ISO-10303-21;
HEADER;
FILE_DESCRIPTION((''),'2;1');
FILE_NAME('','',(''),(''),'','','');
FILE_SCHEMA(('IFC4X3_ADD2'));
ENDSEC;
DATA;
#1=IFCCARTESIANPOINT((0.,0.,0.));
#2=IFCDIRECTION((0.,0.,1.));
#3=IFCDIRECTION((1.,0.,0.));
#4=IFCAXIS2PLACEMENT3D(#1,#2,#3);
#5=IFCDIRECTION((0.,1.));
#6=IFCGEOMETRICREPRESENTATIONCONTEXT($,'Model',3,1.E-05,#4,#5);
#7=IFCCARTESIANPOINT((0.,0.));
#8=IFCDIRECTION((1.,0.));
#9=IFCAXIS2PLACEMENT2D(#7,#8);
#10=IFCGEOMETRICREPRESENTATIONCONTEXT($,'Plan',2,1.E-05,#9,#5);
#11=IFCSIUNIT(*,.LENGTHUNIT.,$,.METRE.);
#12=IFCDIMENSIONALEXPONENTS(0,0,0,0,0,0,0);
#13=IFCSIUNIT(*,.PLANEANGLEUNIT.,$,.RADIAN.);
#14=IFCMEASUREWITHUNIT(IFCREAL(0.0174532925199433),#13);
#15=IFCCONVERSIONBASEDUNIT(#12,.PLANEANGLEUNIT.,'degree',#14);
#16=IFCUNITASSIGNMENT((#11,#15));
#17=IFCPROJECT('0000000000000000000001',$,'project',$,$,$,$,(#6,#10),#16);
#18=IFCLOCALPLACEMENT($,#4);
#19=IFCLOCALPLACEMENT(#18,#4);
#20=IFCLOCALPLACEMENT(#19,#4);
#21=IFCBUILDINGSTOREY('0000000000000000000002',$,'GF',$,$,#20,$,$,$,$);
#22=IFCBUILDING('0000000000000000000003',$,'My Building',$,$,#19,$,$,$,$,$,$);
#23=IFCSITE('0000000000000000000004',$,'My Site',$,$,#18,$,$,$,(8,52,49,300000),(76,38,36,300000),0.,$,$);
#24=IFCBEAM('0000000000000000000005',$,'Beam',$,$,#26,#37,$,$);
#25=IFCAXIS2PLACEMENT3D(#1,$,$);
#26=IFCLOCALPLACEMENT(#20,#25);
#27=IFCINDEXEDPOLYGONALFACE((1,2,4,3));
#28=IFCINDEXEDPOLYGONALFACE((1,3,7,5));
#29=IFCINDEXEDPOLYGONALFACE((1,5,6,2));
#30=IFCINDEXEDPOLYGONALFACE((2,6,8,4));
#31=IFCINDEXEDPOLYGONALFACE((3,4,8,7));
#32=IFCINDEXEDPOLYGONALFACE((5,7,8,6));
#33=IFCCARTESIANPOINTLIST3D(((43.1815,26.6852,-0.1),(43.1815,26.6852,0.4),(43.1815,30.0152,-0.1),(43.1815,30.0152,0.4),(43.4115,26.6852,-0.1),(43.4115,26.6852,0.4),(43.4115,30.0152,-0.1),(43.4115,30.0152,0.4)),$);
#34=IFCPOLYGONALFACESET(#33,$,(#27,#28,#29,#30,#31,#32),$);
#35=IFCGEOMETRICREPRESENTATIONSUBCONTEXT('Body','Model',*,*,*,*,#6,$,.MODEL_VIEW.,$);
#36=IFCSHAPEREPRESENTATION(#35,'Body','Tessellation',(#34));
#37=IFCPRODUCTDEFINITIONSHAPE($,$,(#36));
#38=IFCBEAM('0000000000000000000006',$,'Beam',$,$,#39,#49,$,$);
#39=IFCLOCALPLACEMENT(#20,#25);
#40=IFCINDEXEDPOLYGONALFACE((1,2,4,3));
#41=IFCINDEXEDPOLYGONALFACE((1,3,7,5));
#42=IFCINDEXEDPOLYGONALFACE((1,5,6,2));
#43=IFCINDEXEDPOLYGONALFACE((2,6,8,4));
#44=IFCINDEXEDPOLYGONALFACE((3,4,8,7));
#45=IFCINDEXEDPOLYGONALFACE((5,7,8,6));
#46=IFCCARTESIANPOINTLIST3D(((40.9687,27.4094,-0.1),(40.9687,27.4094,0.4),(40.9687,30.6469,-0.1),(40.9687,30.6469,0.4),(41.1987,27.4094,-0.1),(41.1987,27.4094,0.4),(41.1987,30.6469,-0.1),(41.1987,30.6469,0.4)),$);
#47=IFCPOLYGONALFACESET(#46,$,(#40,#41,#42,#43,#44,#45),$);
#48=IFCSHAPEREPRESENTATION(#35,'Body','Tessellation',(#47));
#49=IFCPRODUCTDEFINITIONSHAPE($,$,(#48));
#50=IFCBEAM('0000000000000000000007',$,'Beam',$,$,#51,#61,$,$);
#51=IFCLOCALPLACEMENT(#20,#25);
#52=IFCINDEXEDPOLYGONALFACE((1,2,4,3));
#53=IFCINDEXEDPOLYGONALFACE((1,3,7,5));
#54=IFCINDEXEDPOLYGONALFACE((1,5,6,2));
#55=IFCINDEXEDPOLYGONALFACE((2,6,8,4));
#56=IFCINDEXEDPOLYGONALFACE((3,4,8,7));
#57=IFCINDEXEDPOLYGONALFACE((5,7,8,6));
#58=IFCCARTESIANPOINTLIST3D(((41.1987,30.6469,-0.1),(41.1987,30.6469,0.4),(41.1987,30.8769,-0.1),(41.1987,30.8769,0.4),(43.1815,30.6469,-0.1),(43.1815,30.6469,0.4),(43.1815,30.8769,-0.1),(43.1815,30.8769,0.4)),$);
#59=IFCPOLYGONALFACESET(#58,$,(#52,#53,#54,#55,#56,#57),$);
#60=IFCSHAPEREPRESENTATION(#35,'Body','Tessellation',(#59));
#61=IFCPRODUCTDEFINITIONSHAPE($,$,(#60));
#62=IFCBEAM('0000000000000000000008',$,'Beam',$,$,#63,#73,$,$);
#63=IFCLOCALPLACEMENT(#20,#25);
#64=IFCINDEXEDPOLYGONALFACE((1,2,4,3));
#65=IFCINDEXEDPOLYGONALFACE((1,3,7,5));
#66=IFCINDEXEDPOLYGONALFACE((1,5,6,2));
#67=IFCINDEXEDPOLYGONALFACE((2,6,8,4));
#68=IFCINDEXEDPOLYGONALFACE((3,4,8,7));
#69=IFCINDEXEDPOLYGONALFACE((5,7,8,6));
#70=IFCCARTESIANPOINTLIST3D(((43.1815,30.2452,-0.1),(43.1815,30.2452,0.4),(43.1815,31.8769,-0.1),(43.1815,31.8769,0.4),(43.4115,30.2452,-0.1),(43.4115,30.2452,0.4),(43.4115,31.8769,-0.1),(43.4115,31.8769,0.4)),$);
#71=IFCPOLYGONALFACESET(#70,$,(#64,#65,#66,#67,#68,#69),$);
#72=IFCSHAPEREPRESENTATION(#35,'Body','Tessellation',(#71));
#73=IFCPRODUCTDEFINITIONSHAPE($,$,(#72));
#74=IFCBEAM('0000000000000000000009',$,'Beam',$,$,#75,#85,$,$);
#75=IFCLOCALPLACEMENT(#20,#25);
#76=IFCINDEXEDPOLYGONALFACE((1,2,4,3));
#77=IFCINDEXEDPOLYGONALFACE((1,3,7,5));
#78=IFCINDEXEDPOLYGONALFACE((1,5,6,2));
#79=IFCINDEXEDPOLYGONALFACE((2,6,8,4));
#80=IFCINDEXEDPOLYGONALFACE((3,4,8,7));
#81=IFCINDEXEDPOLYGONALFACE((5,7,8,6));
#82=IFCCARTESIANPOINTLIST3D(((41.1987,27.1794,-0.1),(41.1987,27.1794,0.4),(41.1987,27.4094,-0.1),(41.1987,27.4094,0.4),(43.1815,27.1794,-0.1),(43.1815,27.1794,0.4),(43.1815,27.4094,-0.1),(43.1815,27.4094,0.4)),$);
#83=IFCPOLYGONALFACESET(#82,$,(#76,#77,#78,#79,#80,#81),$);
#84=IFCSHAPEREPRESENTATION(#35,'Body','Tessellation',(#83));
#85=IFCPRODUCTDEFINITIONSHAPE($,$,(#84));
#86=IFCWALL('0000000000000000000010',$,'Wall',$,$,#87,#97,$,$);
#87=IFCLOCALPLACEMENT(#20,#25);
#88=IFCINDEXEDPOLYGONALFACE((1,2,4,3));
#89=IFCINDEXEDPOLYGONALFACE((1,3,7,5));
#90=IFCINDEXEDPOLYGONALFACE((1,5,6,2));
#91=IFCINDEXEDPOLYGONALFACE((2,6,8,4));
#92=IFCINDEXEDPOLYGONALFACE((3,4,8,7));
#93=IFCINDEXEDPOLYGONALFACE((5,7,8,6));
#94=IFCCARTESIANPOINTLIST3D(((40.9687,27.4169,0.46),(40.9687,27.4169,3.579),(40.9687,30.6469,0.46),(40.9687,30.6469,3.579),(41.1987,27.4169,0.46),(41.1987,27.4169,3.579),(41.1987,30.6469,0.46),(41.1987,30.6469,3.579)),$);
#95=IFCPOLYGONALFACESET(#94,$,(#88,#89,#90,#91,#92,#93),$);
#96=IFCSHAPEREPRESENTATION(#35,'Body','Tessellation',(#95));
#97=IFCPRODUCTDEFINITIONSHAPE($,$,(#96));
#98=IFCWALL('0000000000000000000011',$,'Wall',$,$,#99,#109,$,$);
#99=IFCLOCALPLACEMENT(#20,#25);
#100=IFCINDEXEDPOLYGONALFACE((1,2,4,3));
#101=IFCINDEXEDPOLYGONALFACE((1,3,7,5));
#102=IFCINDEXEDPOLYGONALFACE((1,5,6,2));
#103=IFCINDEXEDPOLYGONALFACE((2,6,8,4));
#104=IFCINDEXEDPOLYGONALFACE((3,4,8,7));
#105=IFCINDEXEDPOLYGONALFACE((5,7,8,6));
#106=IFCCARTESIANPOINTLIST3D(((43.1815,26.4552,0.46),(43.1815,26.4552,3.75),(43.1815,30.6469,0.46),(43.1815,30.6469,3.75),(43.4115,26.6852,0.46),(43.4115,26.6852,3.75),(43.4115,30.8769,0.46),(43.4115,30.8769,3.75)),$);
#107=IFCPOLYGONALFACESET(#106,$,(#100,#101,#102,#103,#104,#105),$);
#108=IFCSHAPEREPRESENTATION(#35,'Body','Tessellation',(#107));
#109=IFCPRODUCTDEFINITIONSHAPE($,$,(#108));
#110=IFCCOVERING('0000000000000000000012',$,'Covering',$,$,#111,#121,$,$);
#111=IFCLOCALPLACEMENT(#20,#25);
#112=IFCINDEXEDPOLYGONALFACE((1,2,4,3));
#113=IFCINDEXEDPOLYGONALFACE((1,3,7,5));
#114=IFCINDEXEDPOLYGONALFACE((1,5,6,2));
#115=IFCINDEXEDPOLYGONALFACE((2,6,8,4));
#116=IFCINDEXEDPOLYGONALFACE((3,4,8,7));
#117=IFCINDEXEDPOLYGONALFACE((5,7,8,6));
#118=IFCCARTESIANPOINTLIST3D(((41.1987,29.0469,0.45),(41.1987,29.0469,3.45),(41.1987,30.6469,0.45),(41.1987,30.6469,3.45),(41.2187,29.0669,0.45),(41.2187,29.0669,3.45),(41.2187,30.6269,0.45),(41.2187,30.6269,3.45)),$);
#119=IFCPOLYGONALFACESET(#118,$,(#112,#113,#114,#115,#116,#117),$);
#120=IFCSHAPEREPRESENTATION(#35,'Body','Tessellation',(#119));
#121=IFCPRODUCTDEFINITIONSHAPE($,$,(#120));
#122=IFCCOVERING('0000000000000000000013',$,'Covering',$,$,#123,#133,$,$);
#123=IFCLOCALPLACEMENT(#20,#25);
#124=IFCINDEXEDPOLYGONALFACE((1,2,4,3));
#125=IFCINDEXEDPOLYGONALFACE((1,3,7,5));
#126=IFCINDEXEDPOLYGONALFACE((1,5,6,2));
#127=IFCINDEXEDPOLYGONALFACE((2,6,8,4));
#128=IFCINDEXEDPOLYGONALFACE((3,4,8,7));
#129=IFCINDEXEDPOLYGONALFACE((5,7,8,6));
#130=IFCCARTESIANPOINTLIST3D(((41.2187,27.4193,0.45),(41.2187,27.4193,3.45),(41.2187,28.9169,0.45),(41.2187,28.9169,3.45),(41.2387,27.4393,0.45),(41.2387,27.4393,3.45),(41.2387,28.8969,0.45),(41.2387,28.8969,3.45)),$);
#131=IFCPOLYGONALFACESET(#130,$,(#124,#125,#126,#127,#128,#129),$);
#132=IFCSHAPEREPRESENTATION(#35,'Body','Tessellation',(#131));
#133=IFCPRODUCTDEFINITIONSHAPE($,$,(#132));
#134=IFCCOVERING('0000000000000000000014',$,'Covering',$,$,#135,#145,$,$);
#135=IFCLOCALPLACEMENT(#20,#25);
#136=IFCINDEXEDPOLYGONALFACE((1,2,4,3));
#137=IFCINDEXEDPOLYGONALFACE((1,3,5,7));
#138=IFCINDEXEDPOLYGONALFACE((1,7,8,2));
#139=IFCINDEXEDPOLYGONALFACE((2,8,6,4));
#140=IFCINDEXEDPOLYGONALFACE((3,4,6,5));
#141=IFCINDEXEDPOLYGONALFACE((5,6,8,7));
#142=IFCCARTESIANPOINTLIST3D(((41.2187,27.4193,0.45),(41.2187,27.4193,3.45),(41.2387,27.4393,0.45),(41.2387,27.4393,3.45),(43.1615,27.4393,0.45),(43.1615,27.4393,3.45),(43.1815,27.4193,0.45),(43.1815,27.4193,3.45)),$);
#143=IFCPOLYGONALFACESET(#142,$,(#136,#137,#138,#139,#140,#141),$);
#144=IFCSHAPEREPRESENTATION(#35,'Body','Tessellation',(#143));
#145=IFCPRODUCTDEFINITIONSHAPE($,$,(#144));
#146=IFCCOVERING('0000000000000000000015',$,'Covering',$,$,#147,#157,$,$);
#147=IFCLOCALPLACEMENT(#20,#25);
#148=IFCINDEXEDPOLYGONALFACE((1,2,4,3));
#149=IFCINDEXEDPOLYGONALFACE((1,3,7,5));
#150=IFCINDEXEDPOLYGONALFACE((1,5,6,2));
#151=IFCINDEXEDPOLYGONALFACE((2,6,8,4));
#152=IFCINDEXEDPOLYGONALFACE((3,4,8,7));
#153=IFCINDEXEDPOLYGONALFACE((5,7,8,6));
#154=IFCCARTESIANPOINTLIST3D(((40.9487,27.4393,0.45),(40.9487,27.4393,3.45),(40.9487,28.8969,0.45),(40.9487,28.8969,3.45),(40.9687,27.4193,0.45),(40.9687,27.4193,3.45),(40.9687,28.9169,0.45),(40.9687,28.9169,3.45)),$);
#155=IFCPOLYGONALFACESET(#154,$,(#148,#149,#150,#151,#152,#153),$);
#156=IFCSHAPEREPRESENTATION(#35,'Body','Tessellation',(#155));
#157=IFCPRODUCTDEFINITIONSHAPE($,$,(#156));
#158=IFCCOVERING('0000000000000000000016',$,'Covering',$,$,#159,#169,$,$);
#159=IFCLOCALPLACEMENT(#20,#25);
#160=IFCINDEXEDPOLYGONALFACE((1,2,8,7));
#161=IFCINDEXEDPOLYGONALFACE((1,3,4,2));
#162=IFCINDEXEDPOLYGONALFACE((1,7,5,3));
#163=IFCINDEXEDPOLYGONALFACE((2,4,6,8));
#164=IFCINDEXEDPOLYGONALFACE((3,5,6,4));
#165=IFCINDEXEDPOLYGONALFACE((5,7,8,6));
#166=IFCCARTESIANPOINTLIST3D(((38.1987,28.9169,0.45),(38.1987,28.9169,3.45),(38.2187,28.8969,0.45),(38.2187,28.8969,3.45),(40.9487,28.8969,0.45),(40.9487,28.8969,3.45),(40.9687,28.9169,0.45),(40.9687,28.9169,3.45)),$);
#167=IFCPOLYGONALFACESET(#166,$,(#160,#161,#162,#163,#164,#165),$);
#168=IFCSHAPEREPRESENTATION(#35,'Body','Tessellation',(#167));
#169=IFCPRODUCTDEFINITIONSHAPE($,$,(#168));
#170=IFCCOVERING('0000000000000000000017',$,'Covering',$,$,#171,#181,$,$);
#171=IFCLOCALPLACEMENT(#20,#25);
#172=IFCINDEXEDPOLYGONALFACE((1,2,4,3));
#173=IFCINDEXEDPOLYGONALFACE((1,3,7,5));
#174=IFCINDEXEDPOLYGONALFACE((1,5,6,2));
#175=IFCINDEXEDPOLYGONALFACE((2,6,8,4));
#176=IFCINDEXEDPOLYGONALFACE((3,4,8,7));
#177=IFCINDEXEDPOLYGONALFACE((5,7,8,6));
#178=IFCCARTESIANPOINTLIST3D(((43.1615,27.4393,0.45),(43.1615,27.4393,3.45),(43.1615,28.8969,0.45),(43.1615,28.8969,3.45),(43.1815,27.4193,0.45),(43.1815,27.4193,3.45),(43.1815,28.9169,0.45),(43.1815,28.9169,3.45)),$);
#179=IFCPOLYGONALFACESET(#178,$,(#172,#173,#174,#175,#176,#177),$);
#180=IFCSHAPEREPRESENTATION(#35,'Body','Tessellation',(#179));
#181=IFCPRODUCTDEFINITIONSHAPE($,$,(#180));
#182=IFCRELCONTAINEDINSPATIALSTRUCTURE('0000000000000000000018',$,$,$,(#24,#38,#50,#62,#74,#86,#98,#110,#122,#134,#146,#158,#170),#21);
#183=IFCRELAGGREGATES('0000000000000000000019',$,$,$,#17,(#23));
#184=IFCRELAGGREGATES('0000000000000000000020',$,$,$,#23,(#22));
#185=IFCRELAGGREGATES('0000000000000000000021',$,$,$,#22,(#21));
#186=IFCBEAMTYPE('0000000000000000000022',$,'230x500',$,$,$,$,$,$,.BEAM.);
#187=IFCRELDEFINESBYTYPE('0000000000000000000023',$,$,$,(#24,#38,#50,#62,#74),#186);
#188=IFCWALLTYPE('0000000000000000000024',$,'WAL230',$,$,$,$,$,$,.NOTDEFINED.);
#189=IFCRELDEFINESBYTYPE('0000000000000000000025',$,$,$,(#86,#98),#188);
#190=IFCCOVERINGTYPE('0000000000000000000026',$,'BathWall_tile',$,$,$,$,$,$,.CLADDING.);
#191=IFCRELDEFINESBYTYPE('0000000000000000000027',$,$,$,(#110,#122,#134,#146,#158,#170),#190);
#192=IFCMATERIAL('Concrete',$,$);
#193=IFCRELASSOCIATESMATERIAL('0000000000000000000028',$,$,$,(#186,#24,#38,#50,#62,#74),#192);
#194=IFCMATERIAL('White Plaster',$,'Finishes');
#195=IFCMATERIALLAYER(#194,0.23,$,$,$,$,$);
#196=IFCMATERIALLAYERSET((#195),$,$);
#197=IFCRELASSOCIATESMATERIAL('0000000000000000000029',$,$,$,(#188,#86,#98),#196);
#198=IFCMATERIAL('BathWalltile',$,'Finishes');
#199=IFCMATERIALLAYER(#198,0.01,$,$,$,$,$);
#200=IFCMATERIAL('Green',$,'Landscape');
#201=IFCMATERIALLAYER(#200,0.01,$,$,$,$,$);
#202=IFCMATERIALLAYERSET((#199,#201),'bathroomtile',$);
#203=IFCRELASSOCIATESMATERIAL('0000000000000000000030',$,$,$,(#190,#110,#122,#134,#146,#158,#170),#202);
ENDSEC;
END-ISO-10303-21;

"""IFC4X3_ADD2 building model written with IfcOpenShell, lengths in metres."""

from ifc_helpers import new_model, entity, si_unit, converted_unit, direction, frame, origin_with_axes, origin_2d_with_axis, place, context, subcontext, project, spatial, line, indexed_curve, rectangle, outline, extrude, material, layer, layer_set, layer_usage, material_profile, profile_set, profile_usage, type_object, element, save


model = new_model("IFC4X3_ADD2")

# Units and contexts
model_context = context("Model", 3, precision=1e-05, world=origin_with_axes(), true_north=direction((0.0, 1.0)))
plan_context = context("Plan", 2, precision=1e-05, world=origin_2d_with_axis(), true_north=direction((0.0, 1.0)))
body_context = subcontext(model_context, "Body", "Model", "MODEL_VIEW")
ifc_project = project(units=[si_unit("LENGTHUNIT", "METRE"), converted_unit("PLANEANGLEUNIT", "degree", entity("IfcReal", 0.0174532925199433), si_unit("PLANEANGLEUNIT", "RADIAN"), dimensions=[0, 0, 0, 0, 0, 0, 0])], contexts=[model_context, plan_context])

# Site, building, storey
site_placement = place(None, origin_with_axes())
site = spatial("IfcSite", under=ifc_project, at=site_placement, Name="My Site", RefLatitude=(8, 52, 49, 300000), RefLongitude=(76, 38, 36, 300000), RefElevation=0.0)
building_placement = place(site_placement, origin_with_axes())
building = spatial("IfcBuilding", under=site, at=building_placement, Name="My Building")
storey_placement = place(building_placement, origin_with_axes())
storey = spatial("IfcBuildingStorey", under=building, at=storey_placement, Name="GF")

# Beams
ifc_material_1 = material(Name="Concrete")
ifc_material_profile_1 = material_profile(ifc_material_1, rectangle(XDim=0.23, YDim=0.5))
ifc_profile_set_1 = profile_set([ifc_material_profile_1])
ifc_profile_usage_1 = profile_usage(ifc_profile_set_1, cardinal=5)
beam_type = type_object("IfcBeamType", Name="230x500", PredefinedType="BEAM", material=ifc_profile_set_1)
beam_1_placement = place(storey_placement, frame((43.2965, 26.6852, 0.15), z_axis=(0.0, 1.0, 0.0), x_axis=(-1.0, 0.0, 0.0)))
element("IfcBeam", 1, at=beam_1_placement, inside=storey, type_object=beam_type, material=ifc_profile_usage_1, Name="Beam", context=body_context, shape_type="SweptSolid", body=[
    extrude(rectangle(XDim=0.23, YDim=0.5), origin_with_axes(), (0.0, 0.0, 1.0), 3.33),
])
ifc_profile_usage_2 = profile_usage(ifc_profile_set_1, cardinal=5)
beam_2_placement = place(storey_placement, frame((41.0837, 27.4094, 0.15), z_axis=(0.0, 1.0, 0.0), x_axis=(-1.0, 0.0, 0.0)))
element("IfcBeam", 2, at=beam_2_placement, inside=storey, type_object=beam_type, material=ifc_profile_usage_2, Name="Beam", context=body_context, shape_type="SweptSolid", body=[
    extrude(rectangle(XDim=0.23, YDim=0.5), origin_with_axes(), (0.0, 0.0, 1.0), 3.2375),
])
ifc_profile_usage_3 = profile_usage(ifc_profile_set_1, cardinal=5)
beam_3_placement = place(storey_placement, frame((41.1987, 30.7619, 0.15), z_axis=(1.0, 0.0, 0.0), x_axis=(0.0, 1.0, 0.0)))
element("IfcBeam", 3, at=beam_3_placement, inside=storey, type_object=beam_type, material=ifc_profile_usage_3, Name="Beam", context=body_context, shape_type="SweptSolid", body=[
    extrude(rectangle(XDim=0.23, YDim=0.5), origin_with_axes(), (0.0, 0.0, 1.0), 1.9828),
])
ifc_profile_usage_4 = profile_usage(ifc_profile_set_1, cardinal=5)
beam_4_placement = place(storey_placement, frame((43.2965, 30.2452, 0.15), z_axis=(0.0, 1.0, 0.0), x_axis=(-1.0, 0.0, 0.0)))
element("IfcBeam", 4, at=beam_4_placement, inside=storey, type_object=beam_type, material=ifc_profile_usage_4, Name="Beam", context=body_context, shape_type="SweptSolid", body=[
    extrude(rectangle(XDim=0.23, YDim=0.5), origin_with_axes(), (0.0, 0.0, 1.0), 1.6317),
])
ifc_profile_usage_5 = profile_usage(ifc_profile_set_1, cardinal=5)
beam_5_placement = place(storey_placement, frame((41.1987, 27.2944, 0.15), z_axis=(1.0, 0.0, 0.0), x_axis=(0.0, 1.0, 0.0)))
element("IfcBeam", 5, at=beam_5_placement, inside=storey, type_object=beam_type, material=ifc_profile_usage_5, Name="Beam", context=body_context, shape_type="SweptSolid", body=[
    extrude(rectangle(XDim=0.23, YDim=0.5), origin_with_axes(), (0.0, 0.0, 1.0), 1.9828),
])

# Walls
ifc_material_2 = material(Name="White Plaster", Category="Finishes")
ifc_layer_1 = layer(ifc_material_2, 0.23)
ifc_layer_set_1 = layer_set([ifc_layer_1])
ifc_layer_usage_1 = layer_usage(ifc_layer_set_1, "AXIS2", "POSITIVE", 0.0)
wall_type_1 = type_object("IfcWallType", Name="WAL230", PredefinedType="NOTDEFINED", material=ifc_layer_set_1)
wall_1_placement = place(storey_placement, frame((41.1987, 27.4169, 0.46), z_axis=(0.0, 0.0, 1.0), x_axis=(0.0, 1.0, 0.0)))
element("IfcWall", 6, at=wall_1_placement, inside=storey, type_object=wall_type_1, material=ifc_layer_usage_1, Name="Wall", context=body_context, shape_type="SweptSolid", body=[
    extrude(outline(indexed_curve([(0.0, 0.0), (0.0, 0.23), (3.23, 0.23), (3.23, 0.0)], segments=[line(1, 2, 3, 4, 1)])), origin_with_axes(), (0.0, 0.0, 1.0), 3.119),
])
ifc_layer_usage_2 = layer_usage(ifc_layer_set_1, "AXIS2", "POSITIVE", 0.0)
wall_2_placement = place(storey_placement, frame((43.4115, 26.6852, 0.46), z_axis=(0.0, 0.0, 1.0), x_axis=(0.0, 1.0, 0.0)))
element("IfcWall", 7, at=wall_2_placement, inside=storey, type_object=wall_type_1, material=ifc_layer_usage_2, Name="Wall", context=body_context, shape_type="SweptSolid", body=[
    extrude(outline(indexed_curve([(0.0, 0.0), (-0.23, 0.23), (3.9617, 0.23), (4.1917, 0.0)], segments=[line(1, 2, 3, 4, 1)])), origin_with_axes(), (0.0, 0.0, 1.0), 3.29),
])

# Coverings
ifc_material_3 = material(Name="BathWalltile", Category="Finishes")
ifc_layer_2 = layer(ifc_material_3, 0.01)
ifc_material_4 = material(Name="Green", Category="Landscape")
ifc_layer_3 = layer(ifc_material_4, 0.01)
ifc_layer_set_2 = layer_set([ifc_layer_2, ifc_layer_3], Name="bathroomtile")
ifc_layer_usage_3 = layer_usage(ifc_layer_set_2, "AXIS2", "NEGATIVE", 0.0)
covering_type_1 = type_object("IfcCoveringType", Name="BathWall_tile", PredefinedType="CLADDING", material=ifc_layer_set_2)
covering_1_placement = place(storey_placement, frame((41.2187, 30.6269, 0.45), z_axis=(0.0, 0.0, 1.0), x_axis=(0.0, -1.0, 0.0)))
element("IfcCovering", 8, at=covering_1_placement, inside=storey, type_object=covering_type_1, material=ifc_layer_usage_3, Name="Covering", context=body_context, shape_type="SweptSolid", body=[
    extrude(outline(indexed_curve([(-0.02, -0.02), (0.0, 0.0), (1.56, 0.0), (1.58, -0.02)], segments=[line(1, 2, 3, 4, 1)])), origin_with_axes(), (0.0, 0.0, 1.0), 3.0),
])
ifc_layer_usage_4 = layer_usage(ifc_layer_set_2, "AXIS2", "POSITIVE", 0.0)
covering_2_placement = place(storey_placement, frame((41.2387, 27.4393, 0.45), z_axis=(0.0, 0.0, 1.0), x_axis=(0.0, 1.0, 0.0)))
element("IfcCovering", 9, at=covering_2_placement, inside=storey, type_object=covering_type_1, material=ifc_layer_usage_4, Name="Covering", context=body_context, shape_type="SweptSolid", body=[
    extrude(outline(indexed_curve([(0.0, 0.0), (-0.02, 0.02), (1.4776, 0.02), (1.4576, 0.0)], segments=[line(1, 2, 3, 4, 1)])), origin_with_axes(), (0.0, 0.0, 1.0), 3.0),
])
ifc_layer_usage_5 = layer_usage(ifc_layer_set_2, "AXIS2", "POSITIVE", 0.0)
covering_3_placement = place(storey_placement, frame((43.1615, 27.4393, 0.45), z_axis=(0.0, 0.0, 1.0), x_axis=(-1.0, 0.0, 0.0)))
element("IfcCovering", 10, at=covering_3_placement, inside=storey, type_object=covering_type_1, material=ifc_layer_usage_5, Name="Covering", context=body_context, shape_type="SweptSolid", body=[
    extrude(outline(indexed_curve([(0.0, 0.0), (-0.02, 0.02), (1.9428, 0.02), (1.9228, 0.0)], segments=[line(1, 2, 3, 4, 1)])), origin_with_axes(), (0.0, 0.0, 1.0), 3.0),
])
ifc_layer_usage_6 = layer_usage(ifc_layer_set_2, "AXIS2", "NEGATIVE", 0.0)
covering_4_placement = place(storey_placement, frame((40.9487, 27.4393, 0.45), z_axis=(0.0, 0.0, 1.0), x_axis=(0.0, 1.0, 0.0)))
element("IfcCovering", 11, at=covering_4_placement, inside=storey, type_object=covering_type_1, material=ifc_layer_usage_6, Name="Covering", context=body_context, shape_type="SweptSolid", body=[
    extrude(outline(indexed_curve([(-0.02, -0.02), (0.0, 0.0), (1.4576, 0.0), (1.4776, -0.02)], segments=[line(1, 2, 3, 4, 1)])), origin_with_axes(), (0.0, 0.0, 1.0), 3.0),
])
ifc_layer_usage_7 = layer_usage(ifc_layer_set_2, "AXIS2", "NEGATIVE", 0.0)
covering_5_placement = place(storey_placement, frame((40.9487, 28.8969, 0.45), z_axis=(0.0, 0.0, 1.0), x_axis=(-1.0, 0.0, 0.0)))
element("IfcCovering", 12, at=covering_5_placement, inside=storey, type_object=covering_type_1, material=ifc_layer_usage_7, Name="Covering", context=body_context, shape_type="SweptSolid", body=[
    extrude(outline(indexed_curve([(-0.02, -0.02), (0.0, 0.0), (2.73, 0.0), (2.75, -0.02)], segments=[line(1, 2, 3, 4, 1)])), origin_with_axes(), (0.0, 0.0, 1.0), 3.0),
])
ifc_layer_usage_8 = layer_usage(ifc_layer_set_2, "AXIS2", "NEGATIVE", 0.0)
covering_6_placement = place(storey_placement, frame((43.1615, 27.4393, 0.45), z_axis=(0.0, 0.0, 1.0), x_axis=(0.0, 1.0, 0.0)))
element("IfcCovering", 13, at=covering_6_placement, inside=storey, type_object=covering_type_1, material=ifc_layer_usage_8, Name="Covering", context=body_context, shape_type="SweptSolid", body=[
    extrude(outline(indexed_curve([(-0.02, -0.02), (0.0, 0.0), (1.4576, 0.0), (1.4776, -0.02)], segments=[line(1, 2, 3, 4, 1)])), origin_with_axes(), (0.0, 0.0, 1.0), 3.0),
])

save(model, "model.ifc")
